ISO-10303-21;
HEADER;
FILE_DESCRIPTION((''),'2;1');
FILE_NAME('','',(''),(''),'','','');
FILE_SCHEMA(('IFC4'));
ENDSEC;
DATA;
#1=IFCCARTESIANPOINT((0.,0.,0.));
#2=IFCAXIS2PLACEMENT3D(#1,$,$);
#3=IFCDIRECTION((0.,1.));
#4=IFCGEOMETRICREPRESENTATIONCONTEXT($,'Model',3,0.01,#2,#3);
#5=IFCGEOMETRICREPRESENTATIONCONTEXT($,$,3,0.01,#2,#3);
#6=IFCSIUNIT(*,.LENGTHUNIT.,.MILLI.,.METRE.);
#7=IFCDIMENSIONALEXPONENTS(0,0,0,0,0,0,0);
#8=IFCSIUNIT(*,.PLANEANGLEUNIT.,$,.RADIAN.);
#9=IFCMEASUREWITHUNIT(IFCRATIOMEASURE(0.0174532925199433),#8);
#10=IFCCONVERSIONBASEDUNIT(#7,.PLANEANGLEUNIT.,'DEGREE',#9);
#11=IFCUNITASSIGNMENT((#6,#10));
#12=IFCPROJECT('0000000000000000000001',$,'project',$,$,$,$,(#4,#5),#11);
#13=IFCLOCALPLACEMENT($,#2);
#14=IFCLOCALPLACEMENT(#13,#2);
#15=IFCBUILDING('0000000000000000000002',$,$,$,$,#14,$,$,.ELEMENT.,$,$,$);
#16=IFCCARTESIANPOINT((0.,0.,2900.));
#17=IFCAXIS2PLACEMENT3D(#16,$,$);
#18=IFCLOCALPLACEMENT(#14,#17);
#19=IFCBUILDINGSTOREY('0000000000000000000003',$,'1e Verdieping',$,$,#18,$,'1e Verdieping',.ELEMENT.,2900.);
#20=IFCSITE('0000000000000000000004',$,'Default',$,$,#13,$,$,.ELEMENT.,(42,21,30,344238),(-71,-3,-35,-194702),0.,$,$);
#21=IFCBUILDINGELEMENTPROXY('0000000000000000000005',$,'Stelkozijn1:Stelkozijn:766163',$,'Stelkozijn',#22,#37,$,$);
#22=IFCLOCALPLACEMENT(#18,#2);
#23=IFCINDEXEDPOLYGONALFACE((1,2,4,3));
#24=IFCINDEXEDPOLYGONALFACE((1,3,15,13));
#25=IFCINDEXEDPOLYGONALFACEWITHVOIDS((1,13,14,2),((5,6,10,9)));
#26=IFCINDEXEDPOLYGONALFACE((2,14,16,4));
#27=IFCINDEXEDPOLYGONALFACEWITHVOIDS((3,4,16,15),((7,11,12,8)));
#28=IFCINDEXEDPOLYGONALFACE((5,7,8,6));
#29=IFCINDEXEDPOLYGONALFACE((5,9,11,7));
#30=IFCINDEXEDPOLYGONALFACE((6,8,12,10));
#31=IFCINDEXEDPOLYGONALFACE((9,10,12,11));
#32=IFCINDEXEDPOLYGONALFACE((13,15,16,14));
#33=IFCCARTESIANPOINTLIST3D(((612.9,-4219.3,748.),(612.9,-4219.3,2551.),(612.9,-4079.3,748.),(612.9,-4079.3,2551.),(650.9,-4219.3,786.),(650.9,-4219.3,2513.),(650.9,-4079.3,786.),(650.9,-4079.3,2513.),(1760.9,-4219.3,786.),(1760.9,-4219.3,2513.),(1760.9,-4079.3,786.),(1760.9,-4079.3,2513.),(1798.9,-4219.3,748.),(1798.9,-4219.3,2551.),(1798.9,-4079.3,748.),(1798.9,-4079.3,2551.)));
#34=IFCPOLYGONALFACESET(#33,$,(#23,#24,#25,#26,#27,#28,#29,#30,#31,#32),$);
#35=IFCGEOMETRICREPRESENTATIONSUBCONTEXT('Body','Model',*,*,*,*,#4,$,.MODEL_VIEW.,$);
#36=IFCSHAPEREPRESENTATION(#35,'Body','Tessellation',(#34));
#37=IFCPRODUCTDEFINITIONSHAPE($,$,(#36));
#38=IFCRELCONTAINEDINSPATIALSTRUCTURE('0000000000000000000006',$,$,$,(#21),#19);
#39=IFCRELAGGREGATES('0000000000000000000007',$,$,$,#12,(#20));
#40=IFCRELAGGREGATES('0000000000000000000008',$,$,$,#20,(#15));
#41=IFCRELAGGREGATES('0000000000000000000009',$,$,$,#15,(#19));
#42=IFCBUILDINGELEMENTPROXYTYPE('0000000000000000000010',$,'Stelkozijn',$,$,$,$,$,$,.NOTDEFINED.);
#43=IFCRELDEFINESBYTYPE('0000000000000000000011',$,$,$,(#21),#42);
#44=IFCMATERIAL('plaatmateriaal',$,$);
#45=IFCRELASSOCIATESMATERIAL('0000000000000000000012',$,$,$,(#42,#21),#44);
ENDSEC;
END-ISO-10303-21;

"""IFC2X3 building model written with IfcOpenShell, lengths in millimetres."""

from ifc_helpers import new_model, entity, si_unit, converted_unit, direction, frame, origin, place, context, subcontext, project, spatial, polyline, outline, extrude, source, transform, mapped, material, type_object, type_shapes, element, save


model = new_model("IFC2X3")

# Units and contexts
model_context = context("Model", 3, precision=0.01, world=origin(), true_north=direction((0.0, 1.0)))
context_of_model = context(None, 3, precision=0.01, world=origin(), true_north=direction((0.0, 1.0)))
body_context = subcontext(model_context, "Body", "Model", "MODEL_VIEW")
ifc_project = project(units=[si_unit("LENGTHUNIT", "METRE", prefix="MILLI"), converted_unit("PLANEANGLEUNIT", "DEGREE", entity("IfcRatioMeasure", 0.0174532925199433), si_unit("PLANEANGLEUNIT", "RADIAN"), dimensions=[0, 0, 0, 0, 0, 0, 0])], contexts=[model_context, context_of_model])

# Site, building, storey
site_placement = place(None, origin())
site = spatial("IfcSite", under=ifc_project, at=site_placement, Name="Default", CompositionType="ELEMENT", RefLatitude=(42, 21, 30, 344238), RefLongitude=(-71, -3, -35, -194702), RefElevation=0.0)
building_placement = place(site_placement, origin())
building = spatial("IfcBuilding", under=site, at=building_placement, CompositionType="ELEMENT")
storey_placement = place(building_placement, frame((0.0, 0.0, 2900.0)))
storey = spatial("IfcBuildingStorey", under=building, at=storey_placement, Name="1e Verdieping", LongName="1e Verdieping", CompositionType="ELEMENT", Elevation=2900.0)

# Building element proxy
ifc_material_1 = material(Name="plaatmateriaal")
building_element_proxy_type_1 = type_object("IfcBuildingElementProxyType", Name="Stelkozijn", PredefinedType="NOTDEFINED", material=ifc_material_1)
shared_shape_1 = source(origin(), body_context, "Body", "SweptSolid", [
    extrude(outline(polyline([(-593.0, -901.5), (593.0, -901.5), (593.0, 901.5), (-593.0, 901.5), (-593.0, -901.5)]), holes=[polyline([(555.0, -863.5), (-555.0, -863.5), (-555.0, 863.5), (555.0, 863.5), (555.0, -863.5)])]), frame((593.0, 0.0, 901.5), z_axis=(0.0, 1.0, 0.0), x_axis=(1.0, 0.0, 0.0)), (0.0, 0.0, 1.0), 140.0),
])
type_shapes(building_element_proxy_type_1, [shared_shape_1])
proxy_1_placement = place(storey_placement, frame((612.9, -4219.3, 748.0)))
element("IfcBuildingElementProxy", 1, at=proxy_1_placement, inside=storey, type_object=building_element_proxy_type_1, material=ifc_material_1, Name="Stelkozijn1:Stelkozijn:766163", ObjectType="Stelkozijn", context=body_context, shape_type="MappedRepresentation", body=[
    mapped(shared_shape_1, transform((0.0, 0.0, 0.0), scale=1.0)),
])

save(model, "model.ifc")
